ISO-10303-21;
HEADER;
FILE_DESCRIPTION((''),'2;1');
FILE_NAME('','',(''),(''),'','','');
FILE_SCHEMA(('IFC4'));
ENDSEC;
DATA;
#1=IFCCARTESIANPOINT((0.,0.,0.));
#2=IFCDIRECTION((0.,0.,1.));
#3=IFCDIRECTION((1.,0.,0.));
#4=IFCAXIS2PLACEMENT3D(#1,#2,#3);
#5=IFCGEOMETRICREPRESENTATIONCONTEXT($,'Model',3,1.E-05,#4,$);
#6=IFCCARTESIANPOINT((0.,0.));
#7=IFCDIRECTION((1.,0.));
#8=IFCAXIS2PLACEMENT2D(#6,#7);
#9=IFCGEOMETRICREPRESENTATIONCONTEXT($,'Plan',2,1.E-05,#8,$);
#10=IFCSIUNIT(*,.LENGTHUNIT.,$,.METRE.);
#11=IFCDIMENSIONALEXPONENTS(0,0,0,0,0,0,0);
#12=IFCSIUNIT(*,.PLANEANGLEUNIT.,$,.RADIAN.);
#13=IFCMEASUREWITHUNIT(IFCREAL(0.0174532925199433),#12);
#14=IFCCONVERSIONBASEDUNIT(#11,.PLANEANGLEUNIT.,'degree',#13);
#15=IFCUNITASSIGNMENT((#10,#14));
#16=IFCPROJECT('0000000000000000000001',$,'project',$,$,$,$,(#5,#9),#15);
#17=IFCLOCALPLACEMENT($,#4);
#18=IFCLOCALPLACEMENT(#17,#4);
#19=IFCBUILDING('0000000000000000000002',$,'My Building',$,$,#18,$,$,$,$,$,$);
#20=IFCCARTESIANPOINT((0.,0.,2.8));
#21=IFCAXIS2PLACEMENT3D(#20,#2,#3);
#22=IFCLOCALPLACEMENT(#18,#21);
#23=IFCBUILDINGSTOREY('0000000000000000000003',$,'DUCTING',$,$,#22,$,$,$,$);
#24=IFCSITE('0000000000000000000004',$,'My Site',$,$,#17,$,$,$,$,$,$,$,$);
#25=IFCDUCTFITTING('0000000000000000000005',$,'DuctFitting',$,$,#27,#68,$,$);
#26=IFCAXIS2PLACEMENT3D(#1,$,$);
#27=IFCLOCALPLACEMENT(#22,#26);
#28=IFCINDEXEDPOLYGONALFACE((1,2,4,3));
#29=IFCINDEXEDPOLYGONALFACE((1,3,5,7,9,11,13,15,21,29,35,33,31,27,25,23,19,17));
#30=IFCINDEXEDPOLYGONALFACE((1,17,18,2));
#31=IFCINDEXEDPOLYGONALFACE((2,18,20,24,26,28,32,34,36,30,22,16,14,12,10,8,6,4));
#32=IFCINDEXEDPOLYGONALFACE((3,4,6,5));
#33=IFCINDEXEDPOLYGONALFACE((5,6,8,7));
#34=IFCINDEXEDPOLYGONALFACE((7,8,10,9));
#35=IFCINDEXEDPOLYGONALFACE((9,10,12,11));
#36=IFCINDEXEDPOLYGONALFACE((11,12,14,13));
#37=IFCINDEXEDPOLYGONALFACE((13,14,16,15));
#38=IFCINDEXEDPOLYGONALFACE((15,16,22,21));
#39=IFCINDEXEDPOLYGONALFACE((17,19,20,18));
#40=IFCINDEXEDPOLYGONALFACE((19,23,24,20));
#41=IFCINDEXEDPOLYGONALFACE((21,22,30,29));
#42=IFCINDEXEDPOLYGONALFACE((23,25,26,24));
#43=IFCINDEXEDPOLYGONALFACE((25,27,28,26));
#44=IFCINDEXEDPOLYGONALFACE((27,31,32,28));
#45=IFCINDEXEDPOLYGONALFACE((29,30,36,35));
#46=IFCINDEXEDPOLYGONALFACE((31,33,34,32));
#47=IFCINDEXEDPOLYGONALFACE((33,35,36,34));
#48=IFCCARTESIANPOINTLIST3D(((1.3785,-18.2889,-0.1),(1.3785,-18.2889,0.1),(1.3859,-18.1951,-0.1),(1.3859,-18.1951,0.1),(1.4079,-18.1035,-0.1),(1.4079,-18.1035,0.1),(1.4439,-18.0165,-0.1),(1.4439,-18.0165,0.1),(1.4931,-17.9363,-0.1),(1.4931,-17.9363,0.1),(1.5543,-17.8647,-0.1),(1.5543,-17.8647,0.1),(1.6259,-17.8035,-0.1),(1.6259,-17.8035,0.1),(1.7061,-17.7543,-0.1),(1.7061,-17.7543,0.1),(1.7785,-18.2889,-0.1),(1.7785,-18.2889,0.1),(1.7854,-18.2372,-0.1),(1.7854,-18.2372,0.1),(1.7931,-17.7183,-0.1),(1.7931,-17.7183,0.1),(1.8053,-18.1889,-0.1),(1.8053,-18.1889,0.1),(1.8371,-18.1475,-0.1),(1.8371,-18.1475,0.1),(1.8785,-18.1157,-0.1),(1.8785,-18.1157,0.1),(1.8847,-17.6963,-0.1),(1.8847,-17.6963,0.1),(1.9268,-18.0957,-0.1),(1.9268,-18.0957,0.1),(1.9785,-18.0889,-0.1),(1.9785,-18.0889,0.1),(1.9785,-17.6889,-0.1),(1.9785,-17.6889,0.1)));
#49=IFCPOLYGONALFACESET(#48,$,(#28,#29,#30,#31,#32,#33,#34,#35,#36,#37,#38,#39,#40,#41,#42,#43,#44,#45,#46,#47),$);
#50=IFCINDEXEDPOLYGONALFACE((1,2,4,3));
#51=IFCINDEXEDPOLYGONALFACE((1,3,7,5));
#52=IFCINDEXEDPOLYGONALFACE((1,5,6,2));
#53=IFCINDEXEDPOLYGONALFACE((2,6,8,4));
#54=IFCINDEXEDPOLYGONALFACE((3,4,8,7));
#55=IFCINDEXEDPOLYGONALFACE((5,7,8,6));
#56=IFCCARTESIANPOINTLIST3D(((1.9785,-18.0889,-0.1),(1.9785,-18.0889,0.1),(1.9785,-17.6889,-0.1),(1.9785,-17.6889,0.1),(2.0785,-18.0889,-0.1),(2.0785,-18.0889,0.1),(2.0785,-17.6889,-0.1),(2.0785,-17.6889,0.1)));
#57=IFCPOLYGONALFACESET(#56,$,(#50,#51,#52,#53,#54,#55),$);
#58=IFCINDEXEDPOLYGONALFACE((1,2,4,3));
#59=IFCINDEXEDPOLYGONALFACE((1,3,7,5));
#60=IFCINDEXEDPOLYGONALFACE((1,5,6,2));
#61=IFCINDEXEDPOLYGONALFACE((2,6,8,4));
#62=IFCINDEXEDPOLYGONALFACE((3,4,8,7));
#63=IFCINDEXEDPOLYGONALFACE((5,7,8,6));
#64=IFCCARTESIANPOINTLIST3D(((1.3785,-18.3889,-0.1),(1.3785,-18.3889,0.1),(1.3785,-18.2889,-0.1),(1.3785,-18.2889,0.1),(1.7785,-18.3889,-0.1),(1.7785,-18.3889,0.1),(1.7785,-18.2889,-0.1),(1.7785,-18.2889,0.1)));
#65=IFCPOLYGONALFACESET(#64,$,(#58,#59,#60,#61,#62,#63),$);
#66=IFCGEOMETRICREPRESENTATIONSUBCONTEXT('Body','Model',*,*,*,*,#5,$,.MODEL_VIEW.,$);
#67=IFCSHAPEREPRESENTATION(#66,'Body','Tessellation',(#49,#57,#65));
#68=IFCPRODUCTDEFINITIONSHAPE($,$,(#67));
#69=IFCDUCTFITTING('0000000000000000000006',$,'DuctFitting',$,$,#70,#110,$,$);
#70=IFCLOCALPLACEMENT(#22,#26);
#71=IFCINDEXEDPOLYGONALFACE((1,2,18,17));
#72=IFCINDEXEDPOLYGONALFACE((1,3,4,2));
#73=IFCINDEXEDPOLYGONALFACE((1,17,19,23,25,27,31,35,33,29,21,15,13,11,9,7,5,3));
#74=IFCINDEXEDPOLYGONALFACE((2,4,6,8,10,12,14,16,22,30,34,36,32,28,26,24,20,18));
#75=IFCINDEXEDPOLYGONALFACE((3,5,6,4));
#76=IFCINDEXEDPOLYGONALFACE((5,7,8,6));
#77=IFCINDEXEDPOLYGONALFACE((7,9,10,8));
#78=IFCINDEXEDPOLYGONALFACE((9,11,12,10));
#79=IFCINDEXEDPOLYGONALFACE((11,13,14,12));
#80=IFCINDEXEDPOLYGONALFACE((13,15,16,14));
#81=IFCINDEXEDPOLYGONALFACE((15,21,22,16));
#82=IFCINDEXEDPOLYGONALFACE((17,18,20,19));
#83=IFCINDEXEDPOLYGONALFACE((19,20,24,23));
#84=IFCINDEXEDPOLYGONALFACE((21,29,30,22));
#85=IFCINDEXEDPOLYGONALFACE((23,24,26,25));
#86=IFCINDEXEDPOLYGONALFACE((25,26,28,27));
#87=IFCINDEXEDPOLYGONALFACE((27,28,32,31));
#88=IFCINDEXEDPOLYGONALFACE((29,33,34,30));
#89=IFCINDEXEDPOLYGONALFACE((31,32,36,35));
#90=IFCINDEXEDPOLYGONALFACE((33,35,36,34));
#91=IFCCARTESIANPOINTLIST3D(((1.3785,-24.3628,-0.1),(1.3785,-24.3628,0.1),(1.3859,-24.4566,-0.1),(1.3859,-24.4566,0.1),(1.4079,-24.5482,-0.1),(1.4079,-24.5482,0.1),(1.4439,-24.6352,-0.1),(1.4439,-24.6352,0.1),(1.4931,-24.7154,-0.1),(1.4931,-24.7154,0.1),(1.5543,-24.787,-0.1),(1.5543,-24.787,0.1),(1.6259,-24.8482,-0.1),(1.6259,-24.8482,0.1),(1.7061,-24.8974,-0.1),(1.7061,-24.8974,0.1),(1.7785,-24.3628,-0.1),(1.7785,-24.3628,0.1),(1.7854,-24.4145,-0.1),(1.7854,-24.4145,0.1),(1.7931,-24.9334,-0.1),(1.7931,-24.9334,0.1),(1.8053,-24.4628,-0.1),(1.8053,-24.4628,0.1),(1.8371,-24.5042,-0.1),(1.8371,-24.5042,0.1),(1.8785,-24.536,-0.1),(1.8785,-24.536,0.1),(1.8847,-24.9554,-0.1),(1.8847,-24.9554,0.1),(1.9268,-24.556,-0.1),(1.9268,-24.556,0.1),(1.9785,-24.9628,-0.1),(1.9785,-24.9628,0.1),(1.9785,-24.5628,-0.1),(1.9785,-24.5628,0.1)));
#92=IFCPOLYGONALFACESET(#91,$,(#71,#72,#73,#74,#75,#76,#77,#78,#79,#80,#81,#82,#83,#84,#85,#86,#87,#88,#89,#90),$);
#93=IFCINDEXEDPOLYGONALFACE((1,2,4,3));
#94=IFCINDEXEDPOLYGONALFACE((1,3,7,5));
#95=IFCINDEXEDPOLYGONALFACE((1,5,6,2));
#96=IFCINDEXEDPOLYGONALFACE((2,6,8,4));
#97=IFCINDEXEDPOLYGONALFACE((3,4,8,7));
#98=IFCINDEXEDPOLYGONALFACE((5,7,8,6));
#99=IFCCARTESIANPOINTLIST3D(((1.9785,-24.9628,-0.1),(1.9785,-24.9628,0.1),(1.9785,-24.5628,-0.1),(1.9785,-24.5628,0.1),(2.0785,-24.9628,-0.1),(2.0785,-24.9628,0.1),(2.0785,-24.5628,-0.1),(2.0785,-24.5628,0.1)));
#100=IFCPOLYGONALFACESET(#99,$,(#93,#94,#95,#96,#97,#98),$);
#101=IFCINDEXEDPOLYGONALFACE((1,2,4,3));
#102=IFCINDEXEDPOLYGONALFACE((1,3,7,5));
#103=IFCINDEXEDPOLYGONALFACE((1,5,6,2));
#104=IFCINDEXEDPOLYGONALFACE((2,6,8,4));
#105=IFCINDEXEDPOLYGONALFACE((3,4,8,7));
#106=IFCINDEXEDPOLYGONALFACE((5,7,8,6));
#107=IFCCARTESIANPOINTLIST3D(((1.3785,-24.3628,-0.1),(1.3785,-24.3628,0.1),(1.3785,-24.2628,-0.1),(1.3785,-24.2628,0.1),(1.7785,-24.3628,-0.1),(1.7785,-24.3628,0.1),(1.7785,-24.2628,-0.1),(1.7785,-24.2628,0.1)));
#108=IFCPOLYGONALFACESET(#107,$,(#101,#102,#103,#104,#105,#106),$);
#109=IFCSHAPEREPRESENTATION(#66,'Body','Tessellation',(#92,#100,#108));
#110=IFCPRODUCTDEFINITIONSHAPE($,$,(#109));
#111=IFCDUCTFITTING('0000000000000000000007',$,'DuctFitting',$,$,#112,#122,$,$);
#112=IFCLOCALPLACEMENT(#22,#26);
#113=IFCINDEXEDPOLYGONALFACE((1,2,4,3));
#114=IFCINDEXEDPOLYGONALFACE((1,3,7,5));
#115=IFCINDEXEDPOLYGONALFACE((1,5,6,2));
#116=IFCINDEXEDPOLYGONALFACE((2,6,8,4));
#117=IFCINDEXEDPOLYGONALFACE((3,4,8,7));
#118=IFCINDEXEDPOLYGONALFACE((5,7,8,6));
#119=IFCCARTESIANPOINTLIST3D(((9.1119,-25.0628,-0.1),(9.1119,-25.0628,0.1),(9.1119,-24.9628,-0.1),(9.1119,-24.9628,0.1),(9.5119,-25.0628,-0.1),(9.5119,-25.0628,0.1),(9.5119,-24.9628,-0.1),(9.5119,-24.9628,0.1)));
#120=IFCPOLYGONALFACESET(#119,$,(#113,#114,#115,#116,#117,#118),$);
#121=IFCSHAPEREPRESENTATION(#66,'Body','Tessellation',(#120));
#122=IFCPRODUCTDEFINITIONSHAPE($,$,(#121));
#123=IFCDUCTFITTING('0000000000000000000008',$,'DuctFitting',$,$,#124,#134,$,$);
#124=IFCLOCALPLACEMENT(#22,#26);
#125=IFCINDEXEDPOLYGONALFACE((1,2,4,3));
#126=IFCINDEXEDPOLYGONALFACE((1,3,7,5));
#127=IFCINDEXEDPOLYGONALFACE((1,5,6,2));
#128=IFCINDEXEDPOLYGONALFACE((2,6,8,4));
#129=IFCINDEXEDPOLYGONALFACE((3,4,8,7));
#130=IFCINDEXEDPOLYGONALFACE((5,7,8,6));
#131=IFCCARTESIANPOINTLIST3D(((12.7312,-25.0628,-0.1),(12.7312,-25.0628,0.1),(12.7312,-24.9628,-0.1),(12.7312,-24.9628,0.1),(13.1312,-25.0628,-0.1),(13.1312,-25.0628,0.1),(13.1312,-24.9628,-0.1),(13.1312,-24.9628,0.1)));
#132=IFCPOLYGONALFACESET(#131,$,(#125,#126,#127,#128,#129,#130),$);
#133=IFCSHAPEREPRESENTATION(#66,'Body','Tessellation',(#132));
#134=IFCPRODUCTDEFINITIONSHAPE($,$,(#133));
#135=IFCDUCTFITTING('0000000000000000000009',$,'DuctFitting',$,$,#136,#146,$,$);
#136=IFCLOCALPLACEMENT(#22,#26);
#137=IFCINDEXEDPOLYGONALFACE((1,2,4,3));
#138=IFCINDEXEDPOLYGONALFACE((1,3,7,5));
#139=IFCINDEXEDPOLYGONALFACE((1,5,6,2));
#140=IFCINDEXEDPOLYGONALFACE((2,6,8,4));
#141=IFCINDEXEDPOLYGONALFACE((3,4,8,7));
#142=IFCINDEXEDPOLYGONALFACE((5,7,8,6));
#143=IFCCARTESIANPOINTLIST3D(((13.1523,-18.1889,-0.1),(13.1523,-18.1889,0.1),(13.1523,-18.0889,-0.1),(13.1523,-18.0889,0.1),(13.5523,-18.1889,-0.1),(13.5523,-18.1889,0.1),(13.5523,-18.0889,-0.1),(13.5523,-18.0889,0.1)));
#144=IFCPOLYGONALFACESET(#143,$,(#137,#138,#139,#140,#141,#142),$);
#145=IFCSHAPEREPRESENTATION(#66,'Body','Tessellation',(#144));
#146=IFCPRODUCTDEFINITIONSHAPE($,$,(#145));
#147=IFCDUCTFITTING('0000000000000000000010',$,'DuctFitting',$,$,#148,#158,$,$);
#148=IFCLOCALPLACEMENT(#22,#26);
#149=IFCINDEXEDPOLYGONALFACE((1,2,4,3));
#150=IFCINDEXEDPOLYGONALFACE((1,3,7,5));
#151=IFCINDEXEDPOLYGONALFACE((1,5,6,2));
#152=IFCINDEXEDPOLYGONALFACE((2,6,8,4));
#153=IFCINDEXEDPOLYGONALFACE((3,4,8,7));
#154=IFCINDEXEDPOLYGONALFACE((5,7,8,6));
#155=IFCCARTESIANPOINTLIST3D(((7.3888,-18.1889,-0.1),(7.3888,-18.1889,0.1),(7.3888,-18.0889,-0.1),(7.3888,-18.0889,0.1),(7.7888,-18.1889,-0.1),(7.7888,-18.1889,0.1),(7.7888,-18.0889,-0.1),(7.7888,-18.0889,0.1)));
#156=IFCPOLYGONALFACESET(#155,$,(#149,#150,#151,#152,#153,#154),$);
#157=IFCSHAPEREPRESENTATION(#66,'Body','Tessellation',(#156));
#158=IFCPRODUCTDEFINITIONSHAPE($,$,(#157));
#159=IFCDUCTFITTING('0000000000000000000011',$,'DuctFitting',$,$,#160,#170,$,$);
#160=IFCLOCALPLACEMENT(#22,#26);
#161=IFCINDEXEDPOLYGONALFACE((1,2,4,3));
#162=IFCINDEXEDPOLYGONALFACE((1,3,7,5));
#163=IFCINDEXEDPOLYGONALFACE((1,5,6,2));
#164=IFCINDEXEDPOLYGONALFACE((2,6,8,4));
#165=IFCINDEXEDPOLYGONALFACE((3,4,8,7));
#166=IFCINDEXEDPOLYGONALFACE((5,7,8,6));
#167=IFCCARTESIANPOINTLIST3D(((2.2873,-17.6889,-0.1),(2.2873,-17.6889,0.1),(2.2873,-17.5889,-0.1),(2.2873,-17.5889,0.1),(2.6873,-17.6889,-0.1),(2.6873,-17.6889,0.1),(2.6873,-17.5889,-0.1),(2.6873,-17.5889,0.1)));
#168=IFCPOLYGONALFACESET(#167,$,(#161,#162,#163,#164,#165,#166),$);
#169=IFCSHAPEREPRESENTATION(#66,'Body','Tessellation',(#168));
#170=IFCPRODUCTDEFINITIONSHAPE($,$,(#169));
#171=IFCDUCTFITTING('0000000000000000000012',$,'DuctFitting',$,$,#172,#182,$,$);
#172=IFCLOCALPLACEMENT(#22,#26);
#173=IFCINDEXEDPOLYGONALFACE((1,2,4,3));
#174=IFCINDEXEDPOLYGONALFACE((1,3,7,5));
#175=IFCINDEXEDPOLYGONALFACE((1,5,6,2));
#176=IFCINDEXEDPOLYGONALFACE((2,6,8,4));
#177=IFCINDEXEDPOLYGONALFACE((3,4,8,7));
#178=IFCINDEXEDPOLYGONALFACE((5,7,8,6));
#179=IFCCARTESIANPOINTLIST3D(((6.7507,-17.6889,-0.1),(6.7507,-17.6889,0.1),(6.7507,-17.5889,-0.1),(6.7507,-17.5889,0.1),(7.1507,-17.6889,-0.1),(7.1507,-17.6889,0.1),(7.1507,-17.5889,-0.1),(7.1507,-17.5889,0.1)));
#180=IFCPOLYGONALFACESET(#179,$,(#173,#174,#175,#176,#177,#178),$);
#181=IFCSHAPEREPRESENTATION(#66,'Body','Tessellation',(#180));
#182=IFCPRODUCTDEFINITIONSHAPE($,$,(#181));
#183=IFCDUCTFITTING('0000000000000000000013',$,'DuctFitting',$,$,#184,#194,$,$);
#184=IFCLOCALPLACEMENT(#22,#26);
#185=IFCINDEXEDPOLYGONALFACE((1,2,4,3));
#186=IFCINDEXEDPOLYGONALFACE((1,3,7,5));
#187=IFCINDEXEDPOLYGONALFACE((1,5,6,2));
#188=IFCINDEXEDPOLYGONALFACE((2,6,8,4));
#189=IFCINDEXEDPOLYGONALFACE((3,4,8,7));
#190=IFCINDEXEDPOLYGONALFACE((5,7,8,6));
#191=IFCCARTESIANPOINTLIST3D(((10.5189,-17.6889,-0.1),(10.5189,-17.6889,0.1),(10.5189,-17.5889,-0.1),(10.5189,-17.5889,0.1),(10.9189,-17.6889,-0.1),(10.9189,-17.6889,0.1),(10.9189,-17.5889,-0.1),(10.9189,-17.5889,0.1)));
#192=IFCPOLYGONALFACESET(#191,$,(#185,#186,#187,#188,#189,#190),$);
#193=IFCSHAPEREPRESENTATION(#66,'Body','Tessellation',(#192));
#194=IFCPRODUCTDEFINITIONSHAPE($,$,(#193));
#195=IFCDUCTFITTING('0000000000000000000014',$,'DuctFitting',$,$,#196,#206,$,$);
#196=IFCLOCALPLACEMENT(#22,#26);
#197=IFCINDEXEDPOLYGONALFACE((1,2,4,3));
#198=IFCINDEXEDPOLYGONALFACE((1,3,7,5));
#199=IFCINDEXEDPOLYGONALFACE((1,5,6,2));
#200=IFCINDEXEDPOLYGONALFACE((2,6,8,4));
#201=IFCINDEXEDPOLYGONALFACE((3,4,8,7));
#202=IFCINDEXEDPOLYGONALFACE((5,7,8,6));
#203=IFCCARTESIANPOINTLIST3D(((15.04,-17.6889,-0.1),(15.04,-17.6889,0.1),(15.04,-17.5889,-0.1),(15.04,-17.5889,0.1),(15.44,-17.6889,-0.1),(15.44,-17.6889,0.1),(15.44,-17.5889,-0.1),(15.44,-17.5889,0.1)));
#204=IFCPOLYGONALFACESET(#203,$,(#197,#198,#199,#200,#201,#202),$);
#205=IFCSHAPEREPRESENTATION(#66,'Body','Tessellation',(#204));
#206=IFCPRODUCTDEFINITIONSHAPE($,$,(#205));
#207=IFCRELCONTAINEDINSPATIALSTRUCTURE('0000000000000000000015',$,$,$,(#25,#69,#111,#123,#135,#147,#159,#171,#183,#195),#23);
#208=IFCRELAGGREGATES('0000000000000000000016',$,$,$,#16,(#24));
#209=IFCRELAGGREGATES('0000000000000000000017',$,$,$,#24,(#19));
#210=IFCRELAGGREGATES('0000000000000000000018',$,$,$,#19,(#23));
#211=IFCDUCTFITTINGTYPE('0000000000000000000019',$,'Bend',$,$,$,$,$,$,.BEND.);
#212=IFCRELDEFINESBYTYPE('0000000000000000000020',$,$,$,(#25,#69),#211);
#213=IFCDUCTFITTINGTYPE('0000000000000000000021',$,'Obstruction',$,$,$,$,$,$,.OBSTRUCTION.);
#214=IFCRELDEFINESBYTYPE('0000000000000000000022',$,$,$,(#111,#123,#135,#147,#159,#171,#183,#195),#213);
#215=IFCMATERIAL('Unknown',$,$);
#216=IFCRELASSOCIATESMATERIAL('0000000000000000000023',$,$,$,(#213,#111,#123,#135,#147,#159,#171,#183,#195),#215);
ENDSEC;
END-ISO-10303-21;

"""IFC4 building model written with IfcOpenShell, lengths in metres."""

from ifc_helpers import new_model, entity, si_unit, converted_unit, frame, origin_with_axes, origin_2d_with_axis, place, context, subcontext, project, spatial, line, arc, indexed_curve, rectangle, outline, extrude, source, transform, mapped, material, material_profile, profile_set, profile_usage, type_object, type_shapes, element, save


model = new_model("IFC4")

# Units and contexts
model_context = context("Model", 3, precision=1e-05, world=origin_with_axes())
plan_context = context("Plan", 2, precision=1e-05, world=origin_2d_with_axis())
body_context = subcontext(model_context, "Body", "Model", "MODEL_VIEW")
ifc_project = project(units=[si_unit("LENGTHUNIT", "METRE"), converted_unit("PLANEANGLEUNIT", "degree", entity("IfcReal", 0.0174532925199433), si_unit("PLANEANGLEUNIT", "RADIAN"), dimensions=[0, 0, 0, 0, 0, 0, 0])], contexts=[model_context, plan_context])

# Site, building, storey
site_placement = place(None, origin_with_axes())
site = spatial("IfcSite", under=ifc_project, at=site_placement, Name="My Site")
building_placement = place(site_placement, origin_with_axes())
building = spatial("IfcBuilding", under=site, at=building_placement, Name="My Building")
storey_placement = place(building_placement, frame((0.0, 0.0, 2.8), z_axis=(0.0, 0.0, 1.0), x_axis=(1.0, 0.0, 0.0)))
storey = spatial("IfcBuildingStorey", under=building, at=storey_placement, Name="DUCTING")

# Shared definitions
ifc_material = material(Name="Unknown")

# Duct fittings
duct_fitting_type_1 = type_object("IfcDuctFittingType", Name="Bend", PredefinedType="BEND")
shared_shape = source(origin_with_axes(), body_context, "Body", "SweptSolid", [
    extrude(outline(indexed_curve([(-0.2, 0.0), (-0.2586, -0.1414), (-0.4, -0.2), (-0.4, -0.6), (0.0243, -0.4243), (0.2, 0.0)], segments=[arc(1, 2, 3), line(3, 4), arc(4, 5, 6), line(6, 1)])), frame((0.0, -0.1, -0.1), z_axis=(0.0, -1.0, 0.0), x_axis=(1.0, 0.0, 0.0)), (0.0, 0.0, -1.0), 0.2),
    extrude(rectangle(XDim=0.4, YDim=0.2), origin_with_axes(), (0.0, 0.0, -1.0), 0.1),
    extrude(rectangle(XDim=0.4, YDim=0.2), frame((-0.4, 0.0, -0.5), z_axis=(-1.0, 0.0, 0.0), x_axis=(0.0, 0.0, -1.0)), (0.0, 0.0, 1.0), 0.1),
])
type_shapes(duct_fitting_type_1, [shared_shape])
for number, where, z_axis, x_axis, name in (
    (1, (2.0785, -17.8889, 0.0), (1.0, 0.0, 0.0), (0.0, 1.0, 0.0), "DuctFitting"),
    (2, (2.0785, -24.7628, 0.0), (1.0, 0.0, 0.0), (0.0, -1.0, 0.0), "DuctFitting"),
):
    element("IfcDuctFitting", number, at=place(storey_placement, frame(where, z_axis=z_axis, x_axis=x_axis)), inside=storey, type_object=duct_fitting_type_1, Name=name, context=body_context, shape_type="MappedRepresentation", body=[
        mapped(shared_shape, transform((0.0, 0.0, 0.0), x_axis=(1.0, 0.0, 0.0), y_axis=(0.0, 1.0, 0.0), z_axis=(0.0, 0.0, 1.0), scale=1.0)),
    ])
ifc_material_profile_1 = material_profile(ifc_material, rectangle(XDim=0.4, YDim=0.2))
ifc_profile_set_1 = profile_set([ifc_material_profile_1])
ifc_profile_usage_1 = profile_usage(ifc_profile_set_1, cardinal=5)
duct_fitting_type_2 = type_object("IfcDuctFittingType", Name="Obstruction", PredefinedType="OBSTRUCTION", material=ifc_profile_set_1)
duct_fitting_1_placement = place(storey_placement, frame((9.3119, -24.9628, 0.0), z_axis=(0.0, -1.0, 0.0), x_axis=(1.0, 0.0, 0.0)))
element("IfcDuctFitting", 3, at=duct_fitting_1_placement, inside=storey, type_object=duct_fitting_type_2, material=ifc_profile_usage_1, Name="DuctFitting", context=body_context, shape_type="SweptSolid", body=[
    extrude(rectangle(XDim=0.4, YDim=0.2), origin_with_axes(), (0.0, 0.0, 1.0), 0.1),
])
ifc_profile_usage_2 = profile_usage(ifc_profile_set_1, cardinal=5)
duct_fitting_2_placement = place(storey_placement, frame((12.9312, -24.9628, 0.0), z_axis=(0.0, -1.0, 0.0), x_axis=(1.0, 0.0, 0.0)))
element("IfcDuctFitting", 4, at=duct_fitting_2_placement, inside=storey, type_object=duct_fitting_type_2, material=ifc_profile_usage_2, Name="DuctFitting", context=body_context, shape_type="SweptSolid", body=[
    extrude(rectangle(XDim=0.4, YDim=0.2), origin_with_axes(), (0.0, 0.0, 1.0), 0.1),
])
ifc_profile_usage_3 = profile_usage(ifc_profile_set_1, cardinal=5)
duct_fitting_3_placement = place(storey_placement, frame((13.3523, -18.0889, 0.0), z_axis=(0.0, -1.0, 0.0), x_axis=(1.0, 0.0, 0.0)))
element("IfcDuctFitting", 5, at=duct_fitting_3_placement, inside=storey, type_object=duct_fitting_type_2, material=ifc_profile_usage_3, Name="DuctFitting", context=body_context, shape_type="SweptSolid", body=[
    extrude(rectangle(XDim=0.4, YDim=0.2), origin_with_axes(), (0.0, 0.0, 1.0), 0.1),
])
ifc_profile_usage_4 = profile_usage(ifc_profile_set_1, cardinal=5)
duct_fitting_4_placement = place(storey_placement, frame((7.5888, -18.0889, 0.0), z_axis=(0.0, -1.0, 0.0), x_axis=(1.0, 0.0, 0.0)))
element("IfcDuctFitting", 6, at=duct_fitting_4_placement, inside=storey, type_object=duct_fitting_type_2, material=ifc_profile_usage_4, Name="DuctFitting", context=body_context, shape_type="SweptSolid", body=[
    extrude(rectangle(XDim=0.4, YDim=0.2), origin_with_axes(), (0.0, 0.0, 1.0), 0.1),
])
ifc_profile_usage_5 = profile_usage(ifc_profile_set_1, cardinal=5)
duct_fitting_5_placement = place(storey_placement, frame((2.4873, -17.6889, 0.0), z_axis=(0.0, 1.0, 0.0), x_axis=(-1.0, 0.0, 0.0)))
element("IfcDuctFitting", 7, at=duct_fitting_5_placement, inside=storey, type_object=duct_fitting_type_2, material=ifc_profile_usage_5, Name="DuctFitting", context=body_context, shape_type="SweptSolid", body=[
    extrude(rectangle(XDim=0.4, YDim=0.2), origin_with_axes(), (0.0, 0.0, 1.0), 0.1),
])
ifc_profile_usage_6 = profile_usage(ifc_profile_set_1, cardinal=5)
duct_fitting_6_placement = place(storey_placement, frame((6.9507, -17.6889, 0.0), z_axis=(0.0, 1.0, 0.0), x_axis=(-1.0, 0.0, 0.0)))
element("IfcDuctFitting", 8, at=duct_fitting_6_placement, inside=storey, type_object=duct_fitting_type_2, material=ifc_profile_usage_6, Name="DuctFitting", context=body_context, shape_type="SweptSolid", body=[
    extrude(rectangle(XDim=0.4, YDim=0.2), origin_with_axes(), (0.0, 0.0, 1.0), 0.1),
])
ifc_profile_usage_7 = profile_usage(ifc_profile_set_1, cardinal=5)
duct_fitting_7_placement = place(storey_placement, frame((10.7189, -17.6889, 0.0), z_axis=(0.0, 1.0, 0.0), x_axis=(-1.0, 0.0, 0.0)))
element("IfcDuctFitting", 9, at=duct_fitting_7_placement, inside=storey, type_object=duct_fitting_type_2, material=ifc_profile_usage_7, Name="DuctFitting", context=body_context, shape_type="SweptSolid", body=[
    extrude(rectangle(XDim=0.4, YDim=0.2), origin_with_axes(), (0.0, 0.0, 1.0), 0.1),
])
ifc_profile_usage_8 = profile_usage(ifc_profile_set_1, cardinal=5)
duct_fitting_8_placement = place(storey_placement, frame((15.24, -17.6889, 0.0), z_axis=(0.0, 1.0, 0.0), x_axis=(-1.0, 0.0, 0.0)))
element("IfcDuctFitting", 10, at=duct_fitting_8_placement, inside=storey, type_object=duct_fitting_type_2, material=ifc_profile_usage_8, Name="DuctFitting", context=body_context, shape_type="SweptSolid", body=[
    extrude(rectangle(XDim=0.4, YDim=0.2), origin_with_axes(), (0.0, 0.0, 1.0), 0.1),
])

save(model, "model.ifc")
